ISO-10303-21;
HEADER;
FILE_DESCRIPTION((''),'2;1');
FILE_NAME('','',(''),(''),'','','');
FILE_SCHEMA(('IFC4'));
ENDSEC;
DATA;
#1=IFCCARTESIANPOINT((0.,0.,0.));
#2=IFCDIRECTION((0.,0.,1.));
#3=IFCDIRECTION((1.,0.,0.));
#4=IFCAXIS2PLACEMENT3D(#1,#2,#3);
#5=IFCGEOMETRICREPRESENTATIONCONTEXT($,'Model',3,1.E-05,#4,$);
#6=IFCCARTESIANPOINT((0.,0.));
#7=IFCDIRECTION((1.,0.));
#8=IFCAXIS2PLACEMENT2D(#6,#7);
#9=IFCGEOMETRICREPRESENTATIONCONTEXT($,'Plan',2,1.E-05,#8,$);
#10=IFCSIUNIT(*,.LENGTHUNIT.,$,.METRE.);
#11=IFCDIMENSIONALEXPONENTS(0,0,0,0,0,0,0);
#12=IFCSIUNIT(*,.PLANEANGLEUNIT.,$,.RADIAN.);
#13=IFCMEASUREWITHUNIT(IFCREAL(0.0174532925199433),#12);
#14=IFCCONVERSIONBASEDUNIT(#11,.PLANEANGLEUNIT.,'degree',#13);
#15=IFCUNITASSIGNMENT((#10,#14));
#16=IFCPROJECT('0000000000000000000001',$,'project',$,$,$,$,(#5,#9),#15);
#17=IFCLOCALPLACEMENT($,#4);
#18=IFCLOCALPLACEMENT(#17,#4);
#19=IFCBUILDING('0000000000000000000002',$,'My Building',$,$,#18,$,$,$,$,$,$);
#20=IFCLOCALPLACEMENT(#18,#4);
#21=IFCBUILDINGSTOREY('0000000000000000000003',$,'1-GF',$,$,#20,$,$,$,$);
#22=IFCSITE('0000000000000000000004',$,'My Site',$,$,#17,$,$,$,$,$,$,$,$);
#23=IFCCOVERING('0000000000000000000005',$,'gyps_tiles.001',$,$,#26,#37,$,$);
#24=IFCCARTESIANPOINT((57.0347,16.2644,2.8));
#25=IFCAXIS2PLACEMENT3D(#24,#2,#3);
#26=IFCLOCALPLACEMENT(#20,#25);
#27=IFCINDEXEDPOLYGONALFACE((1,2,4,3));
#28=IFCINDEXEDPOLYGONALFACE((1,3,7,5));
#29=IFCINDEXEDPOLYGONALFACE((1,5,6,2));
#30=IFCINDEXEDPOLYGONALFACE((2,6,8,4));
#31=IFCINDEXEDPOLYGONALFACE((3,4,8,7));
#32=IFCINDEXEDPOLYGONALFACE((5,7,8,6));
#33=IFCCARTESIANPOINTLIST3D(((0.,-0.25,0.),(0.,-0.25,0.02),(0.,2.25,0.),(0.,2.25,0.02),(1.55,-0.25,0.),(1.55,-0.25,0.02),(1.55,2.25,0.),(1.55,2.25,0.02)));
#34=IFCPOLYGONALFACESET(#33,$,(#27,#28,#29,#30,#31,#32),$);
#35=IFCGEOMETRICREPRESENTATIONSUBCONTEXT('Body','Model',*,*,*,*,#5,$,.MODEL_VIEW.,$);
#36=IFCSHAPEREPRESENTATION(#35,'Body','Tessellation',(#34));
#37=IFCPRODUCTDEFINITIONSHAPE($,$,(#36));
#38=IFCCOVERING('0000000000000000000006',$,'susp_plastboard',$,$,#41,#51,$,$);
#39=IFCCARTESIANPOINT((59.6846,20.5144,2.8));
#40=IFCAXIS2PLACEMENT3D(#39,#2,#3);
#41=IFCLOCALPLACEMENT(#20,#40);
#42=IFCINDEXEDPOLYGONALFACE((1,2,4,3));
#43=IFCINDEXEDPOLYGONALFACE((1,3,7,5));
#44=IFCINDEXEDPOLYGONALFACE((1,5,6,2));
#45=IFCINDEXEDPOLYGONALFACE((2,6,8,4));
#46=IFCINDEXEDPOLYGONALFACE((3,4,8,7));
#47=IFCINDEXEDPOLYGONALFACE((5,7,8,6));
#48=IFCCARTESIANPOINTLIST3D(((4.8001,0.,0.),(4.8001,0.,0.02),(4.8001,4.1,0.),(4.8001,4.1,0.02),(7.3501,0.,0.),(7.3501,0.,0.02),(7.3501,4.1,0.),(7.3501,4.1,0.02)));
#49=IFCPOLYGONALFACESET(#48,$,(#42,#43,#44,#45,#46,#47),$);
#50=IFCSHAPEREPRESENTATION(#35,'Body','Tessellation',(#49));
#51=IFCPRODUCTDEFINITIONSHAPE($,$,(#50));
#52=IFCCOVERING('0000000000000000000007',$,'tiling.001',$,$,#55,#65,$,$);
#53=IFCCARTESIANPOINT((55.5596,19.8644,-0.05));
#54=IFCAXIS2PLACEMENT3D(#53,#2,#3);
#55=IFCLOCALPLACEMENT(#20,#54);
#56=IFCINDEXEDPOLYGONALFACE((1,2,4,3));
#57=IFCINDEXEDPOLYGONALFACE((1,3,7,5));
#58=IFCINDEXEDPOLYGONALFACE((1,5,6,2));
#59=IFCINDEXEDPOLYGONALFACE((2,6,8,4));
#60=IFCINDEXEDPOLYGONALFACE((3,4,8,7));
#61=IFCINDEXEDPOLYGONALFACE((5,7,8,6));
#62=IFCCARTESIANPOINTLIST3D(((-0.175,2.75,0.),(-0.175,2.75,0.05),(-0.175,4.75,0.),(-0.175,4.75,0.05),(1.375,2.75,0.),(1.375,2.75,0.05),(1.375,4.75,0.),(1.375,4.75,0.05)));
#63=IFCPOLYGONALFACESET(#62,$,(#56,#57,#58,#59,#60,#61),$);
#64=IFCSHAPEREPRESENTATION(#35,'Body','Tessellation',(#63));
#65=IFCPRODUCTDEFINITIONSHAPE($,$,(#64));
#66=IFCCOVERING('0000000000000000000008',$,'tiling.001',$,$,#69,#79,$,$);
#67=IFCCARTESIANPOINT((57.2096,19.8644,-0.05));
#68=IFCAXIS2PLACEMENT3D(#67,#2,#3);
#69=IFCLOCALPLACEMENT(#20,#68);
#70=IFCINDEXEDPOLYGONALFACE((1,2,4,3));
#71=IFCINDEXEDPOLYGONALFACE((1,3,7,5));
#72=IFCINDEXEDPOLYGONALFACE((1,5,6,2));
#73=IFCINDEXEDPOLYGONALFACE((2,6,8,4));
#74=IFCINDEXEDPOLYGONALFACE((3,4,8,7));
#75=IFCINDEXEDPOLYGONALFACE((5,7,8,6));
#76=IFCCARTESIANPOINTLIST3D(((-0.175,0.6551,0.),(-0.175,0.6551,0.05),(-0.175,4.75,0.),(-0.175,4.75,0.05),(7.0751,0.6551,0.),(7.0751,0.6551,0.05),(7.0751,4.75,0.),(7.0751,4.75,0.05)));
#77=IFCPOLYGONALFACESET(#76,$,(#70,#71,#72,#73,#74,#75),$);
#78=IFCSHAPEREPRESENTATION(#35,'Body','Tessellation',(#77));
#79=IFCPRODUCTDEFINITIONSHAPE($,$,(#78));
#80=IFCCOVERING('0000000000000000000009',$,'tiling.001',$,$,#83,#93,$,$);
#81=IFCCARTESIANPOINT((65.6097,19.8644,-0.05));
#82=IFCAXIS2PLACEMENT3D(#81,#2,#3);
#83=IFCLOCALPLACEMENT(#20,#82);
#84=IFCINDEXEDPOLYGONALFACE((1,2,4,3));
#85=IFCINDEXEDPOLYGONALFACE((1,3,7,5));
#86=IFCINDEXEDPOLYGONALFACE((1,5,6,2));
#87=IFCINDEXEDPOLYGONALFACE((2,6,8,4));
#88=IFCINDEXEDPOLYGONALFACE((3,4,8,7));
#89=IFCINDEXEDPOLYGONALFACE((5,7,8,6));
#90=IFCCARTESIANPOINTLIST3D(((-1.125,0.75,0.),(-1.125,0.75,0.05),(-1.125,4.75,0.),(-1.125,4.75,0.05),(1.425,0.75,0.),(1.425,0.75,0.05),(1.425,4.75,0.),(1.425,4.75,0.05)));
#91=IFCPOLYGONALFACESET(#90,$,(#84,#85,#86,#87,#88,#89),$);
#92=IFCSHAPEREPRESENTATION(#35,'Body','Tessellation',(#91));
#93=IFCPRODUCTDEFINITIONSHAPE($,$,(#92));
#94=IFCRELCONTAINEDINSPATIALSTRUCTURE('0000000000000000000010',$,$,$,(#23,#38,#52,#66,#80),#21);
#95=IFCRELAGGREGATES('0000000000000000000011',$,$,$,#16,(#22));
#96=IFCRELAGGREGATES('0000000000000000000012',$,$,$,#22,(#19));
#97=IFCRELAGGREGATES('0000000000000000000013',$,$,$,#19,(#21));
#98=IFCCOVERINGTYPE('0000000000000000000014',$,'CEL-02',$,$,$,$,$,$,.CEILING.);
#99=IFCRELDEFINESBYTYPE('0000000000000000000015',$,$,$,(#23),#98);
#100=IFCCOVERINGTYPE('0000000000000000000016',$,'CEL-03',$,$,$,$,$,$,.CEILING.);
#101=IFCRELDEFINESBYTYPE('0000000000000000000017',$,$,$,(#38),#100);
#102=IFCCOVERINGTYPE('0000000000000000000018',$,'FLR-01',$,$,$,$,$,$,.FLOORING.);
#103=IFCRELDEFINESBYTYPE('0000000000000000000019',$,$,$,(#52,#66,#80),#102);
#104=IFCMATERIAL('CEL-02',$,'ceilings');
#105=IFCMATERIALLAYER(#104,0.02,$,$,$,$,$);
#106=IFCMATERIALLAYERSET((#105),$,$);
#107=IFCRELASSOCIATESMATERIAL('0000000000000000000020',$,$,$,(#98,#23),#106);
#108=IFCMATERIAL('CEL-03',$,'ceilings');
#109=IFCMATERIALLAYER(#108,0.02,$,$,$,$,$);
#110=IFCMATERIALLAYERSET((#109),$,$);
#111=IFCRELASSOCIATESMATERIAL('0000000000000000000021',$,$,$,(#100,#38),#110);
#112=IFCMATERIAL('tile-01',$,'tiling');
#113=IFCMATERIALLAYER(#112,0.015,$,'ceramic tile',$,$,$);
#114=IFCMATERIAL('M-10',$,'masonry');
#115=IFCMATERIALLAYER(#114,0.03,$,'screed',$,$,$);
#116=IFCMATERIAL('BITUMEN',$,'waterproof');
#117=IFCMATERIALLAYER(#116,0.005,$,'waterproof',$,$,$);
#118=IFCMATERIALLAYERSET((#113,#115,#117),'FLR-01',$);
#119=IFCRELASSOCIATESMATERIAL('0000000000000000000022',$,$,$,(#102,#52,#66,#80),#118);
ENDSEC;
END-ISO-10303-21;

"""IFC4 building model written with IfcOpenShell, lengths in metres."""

from ifc_helpers import new_model, entity, si_unit, converted_unit, frame, origin_with_axes, origin_2d_with_axis, place, context, subcontext, project, spatial, line, indexed_curve, outline, extrude, material, layer, layer_set, layer_usage, type_object, element, save


model = new_model("IFC4")

# Units and contexts
model_context = context("Model", 3, precision=1e-05, world=origin_with_axes())
plan_context = context("Plan", 2, precision=1e-05, world=origin_2d_with_axis())
body_context_1 = subcontext(model_context, "Body", "Model", "MODEL_VIEW")
ifc_project = project(units=[si_unit("LENGTHUNIT", "METRE"), converted_unit("PLANEANGLEUNIT", "degree", entity("IfcReal", 0.0174532925199433), si_unit("PLANEANGLEUNIT", "RADIAN"), dimensions=[0, 0, 0, 0, 0, 0, 0])], contexts=[model_context, plan_context])

# Site, building, storey
site_placement = place(None, origin_with_axes())
site = spatial("IfcSite", under=ifc_project, at=site_placement, Name="My Site")
building_placement = place(site_placement, origin_with_axes())
building = spatial("IfcBuilding", under=site, at=building_placement, Name="My Building")
storey_placement = place(building_placement, origin_with_axes())
storey = spatial("IfcBuildingStorey", under=building, at=storey_placement, Name="1-GF")

# Coverings
ifc_material_1 = material(Name="M-10", Category="masonry")
ifc_material_2 = material(Name="CEL-02", Category="ceilings")
ifc_layer_1 = layer(ifc_material_2, 0.02)
ifc_layer_set_1 = layer_set([ifc_layer_1])
ifc_layer_usage_1 = layer_usage(ifc_layer_set_1, "AXIS3", "POSITIVE", 0.0)
covering_type_1 = type_object("IfcCoveringType", Name="CEL-02", PredefinedType="CEILING", material=ifc_layer_set_1)
covering_1_placement = place(storey_placement, frame((57.0347, 16.2644, 2.8), z_axis=(0.0, 0.0, 1.0), x_axis=(1.0, 0.0, 0.0)))
element("IfcCovering", 1, at=covering_1_placement, inside=storey, type_object=covering_type_1, material=ifc_layer_usage_1, Name="gyps_tiles.001", context=body_context_1, shape_type="SweptSolid", body=[
    extrude(outline(indexed_curve([(1.55, 2.25), (1.55, -0.25), (0.0, -0.25), (0.0, 2.25)], segments=[line(3, 2), line(2, 1), line(1, 4), line(4, 3)], self_intersect=False)), None, (0.0, 0.0, 1.0), 0.02),
])
ifc_material_3 = material(Name="CEL-03", Category="ceilings")
ifc_layer_2 = layer(ifc_material_3, 0.02)
ifc_layer_set_2 = layer_set([ifc_layer_2])
covering_type_2 = type_object("IfcCoveringType", Name="CEL-03", PredefinedType="CEILING", material=ifc_layer_set_2)
ifc_layer_usage_2 = layer_usage(ifc_layer_set_2, "AXIS3", "POSITIVE", 0.0)
covering_2_placement = place(storey_placement, frame((59.6846, 20.5144, 2.8), z_axis=(0.0, 0.0, 1.0), x_axis=(1.0, 0.0, 0.0)))
element("IfcCovering", 2, at=covering_2_placement, inside=storey, type_object=covering_type_2, material=ifc_layer_usage_2, Name="susp_plastboard", context=body_context_1, shape_type="SweptSolid", body=[
    extrude(outline(indexed_curve([(4.8001, 4.1), (4.8001, 0.0), (7.3501, 0.0), (7.3501, 4.1)], segments=[line(3, 2), line(2, 1), line(1, 4), line(4, 3)], self_intersect=False)), None, (0.0, 0.0, 1.0), 0.02),
])
ifc_material_4 = material(Name="tile-01", Category="tiling")
ifc_layer_3 = layer(ifc_material_4, 0.015, Name="ceramic tile")
ifc_layer_4 = layer(ifc_material_1, 0.03, Name="screed")
ifc_material_5 = material(Name="BITUMEN", Category="waterproof")
ifc_layer_5 = layer(ifc_material_5, 0.005, Name="waterproof")
ifc_layer_set_3 = layer_set([ifc_layer_3, ifc_layer_4, ifc_layer_5], Name="FLR-01")
ifc_layer_usage_3 = layer_usage(ifc_layer_set_3, "AXIS3", "POSITIVE", 0.0)
covering_type_3 = type_object("IfcCoveringType", Name="FLR-01", PredefinedType="FLOORING", material=ifc_layer_set_3)
covering_3_placement = place(storey_placement, frame((55.5596, 19.8644, -0.05), z_axis=(0.0, 0.0, 1.0), x_axis=(1.0, 0.0, 0.0)))
element("IfcCovering", 3, at=covering_3_placement, inside=storey, type_object=covering_type_3, material=ifc_layer_usage_3, Name="tiling.001", context=body_context_1, shape_type="SweptSolid", body=[
    extrude(outline(indexed_curve([(-0.175, 4.75), (1.375, 4.75), (1.375, 2.75), (-0.175, 2.75)], segments=[line(4, 1), line(1, 2), line(2, 3), line(3, 4)], self_intersect=False)), None, (0.0, 0.0, 1.0), 0.05),
])
ifc_layer_usage_4 = layer_usage(ifc_layer_set_3, "AXIS3", "POSITIVE", 0.0)
covering_4_placement = place(storey_placement, frame((57.2096, 19.8644, -0.05), z_axis=(0.0, 0.0, 1.0), x_axis=(1.0, 0.0, 0.0)))
element("IfcCovering", 4, at=covering_4_placement, inside=storey, type_object=covering_type_3, material=ifc_layer_usage_4, Name="tiling.001", context=body_context_1, shape_type="SweptSolid", body=[
    extrude(outline(indexed_curve([(-0.175, 0.6551), (-0.175, 4.75), (7.0751, 4.75), (7.0751, 0.6551)], segments=[line(3, 2), line(2, 1), line(1, 4), line(4, 3)], self_intersect=False)), None, (0.0, 0.0, 1.0), 0.05),
])
ifc_layer_usage_5 = layer_usage(ifc_layer_set_3, "AXIS3", "POSITIVE", 0.0)
covering_5_placement = place(storey_placement, frame((65.6097, 19.8644, -0.05), z_axis=(0.0, 0.0, 1.0), x_axis=(1.0, 0.0, 0.0)))
element("IfcCovering", 5, at=covering_5_placement, inside=storey, type_object=covering_type_3, material=ifc_layer_usage_5, Name="tiling.001", context=body_context_1, shape_type="SweptSolid", body=[
    extrude(outline(indexed_curve([(1.425, 4.75), (-1.125, 4.75), (-1.125, 0.75), (1.425, 0.75)], segments=[line(4, 1), line(1, 2), line(2, 3), line(3, 4)], self_intersect=False)), None, (0.0, 0.0, 1.0), 0.05),
])

save(model, "model.ifc")
